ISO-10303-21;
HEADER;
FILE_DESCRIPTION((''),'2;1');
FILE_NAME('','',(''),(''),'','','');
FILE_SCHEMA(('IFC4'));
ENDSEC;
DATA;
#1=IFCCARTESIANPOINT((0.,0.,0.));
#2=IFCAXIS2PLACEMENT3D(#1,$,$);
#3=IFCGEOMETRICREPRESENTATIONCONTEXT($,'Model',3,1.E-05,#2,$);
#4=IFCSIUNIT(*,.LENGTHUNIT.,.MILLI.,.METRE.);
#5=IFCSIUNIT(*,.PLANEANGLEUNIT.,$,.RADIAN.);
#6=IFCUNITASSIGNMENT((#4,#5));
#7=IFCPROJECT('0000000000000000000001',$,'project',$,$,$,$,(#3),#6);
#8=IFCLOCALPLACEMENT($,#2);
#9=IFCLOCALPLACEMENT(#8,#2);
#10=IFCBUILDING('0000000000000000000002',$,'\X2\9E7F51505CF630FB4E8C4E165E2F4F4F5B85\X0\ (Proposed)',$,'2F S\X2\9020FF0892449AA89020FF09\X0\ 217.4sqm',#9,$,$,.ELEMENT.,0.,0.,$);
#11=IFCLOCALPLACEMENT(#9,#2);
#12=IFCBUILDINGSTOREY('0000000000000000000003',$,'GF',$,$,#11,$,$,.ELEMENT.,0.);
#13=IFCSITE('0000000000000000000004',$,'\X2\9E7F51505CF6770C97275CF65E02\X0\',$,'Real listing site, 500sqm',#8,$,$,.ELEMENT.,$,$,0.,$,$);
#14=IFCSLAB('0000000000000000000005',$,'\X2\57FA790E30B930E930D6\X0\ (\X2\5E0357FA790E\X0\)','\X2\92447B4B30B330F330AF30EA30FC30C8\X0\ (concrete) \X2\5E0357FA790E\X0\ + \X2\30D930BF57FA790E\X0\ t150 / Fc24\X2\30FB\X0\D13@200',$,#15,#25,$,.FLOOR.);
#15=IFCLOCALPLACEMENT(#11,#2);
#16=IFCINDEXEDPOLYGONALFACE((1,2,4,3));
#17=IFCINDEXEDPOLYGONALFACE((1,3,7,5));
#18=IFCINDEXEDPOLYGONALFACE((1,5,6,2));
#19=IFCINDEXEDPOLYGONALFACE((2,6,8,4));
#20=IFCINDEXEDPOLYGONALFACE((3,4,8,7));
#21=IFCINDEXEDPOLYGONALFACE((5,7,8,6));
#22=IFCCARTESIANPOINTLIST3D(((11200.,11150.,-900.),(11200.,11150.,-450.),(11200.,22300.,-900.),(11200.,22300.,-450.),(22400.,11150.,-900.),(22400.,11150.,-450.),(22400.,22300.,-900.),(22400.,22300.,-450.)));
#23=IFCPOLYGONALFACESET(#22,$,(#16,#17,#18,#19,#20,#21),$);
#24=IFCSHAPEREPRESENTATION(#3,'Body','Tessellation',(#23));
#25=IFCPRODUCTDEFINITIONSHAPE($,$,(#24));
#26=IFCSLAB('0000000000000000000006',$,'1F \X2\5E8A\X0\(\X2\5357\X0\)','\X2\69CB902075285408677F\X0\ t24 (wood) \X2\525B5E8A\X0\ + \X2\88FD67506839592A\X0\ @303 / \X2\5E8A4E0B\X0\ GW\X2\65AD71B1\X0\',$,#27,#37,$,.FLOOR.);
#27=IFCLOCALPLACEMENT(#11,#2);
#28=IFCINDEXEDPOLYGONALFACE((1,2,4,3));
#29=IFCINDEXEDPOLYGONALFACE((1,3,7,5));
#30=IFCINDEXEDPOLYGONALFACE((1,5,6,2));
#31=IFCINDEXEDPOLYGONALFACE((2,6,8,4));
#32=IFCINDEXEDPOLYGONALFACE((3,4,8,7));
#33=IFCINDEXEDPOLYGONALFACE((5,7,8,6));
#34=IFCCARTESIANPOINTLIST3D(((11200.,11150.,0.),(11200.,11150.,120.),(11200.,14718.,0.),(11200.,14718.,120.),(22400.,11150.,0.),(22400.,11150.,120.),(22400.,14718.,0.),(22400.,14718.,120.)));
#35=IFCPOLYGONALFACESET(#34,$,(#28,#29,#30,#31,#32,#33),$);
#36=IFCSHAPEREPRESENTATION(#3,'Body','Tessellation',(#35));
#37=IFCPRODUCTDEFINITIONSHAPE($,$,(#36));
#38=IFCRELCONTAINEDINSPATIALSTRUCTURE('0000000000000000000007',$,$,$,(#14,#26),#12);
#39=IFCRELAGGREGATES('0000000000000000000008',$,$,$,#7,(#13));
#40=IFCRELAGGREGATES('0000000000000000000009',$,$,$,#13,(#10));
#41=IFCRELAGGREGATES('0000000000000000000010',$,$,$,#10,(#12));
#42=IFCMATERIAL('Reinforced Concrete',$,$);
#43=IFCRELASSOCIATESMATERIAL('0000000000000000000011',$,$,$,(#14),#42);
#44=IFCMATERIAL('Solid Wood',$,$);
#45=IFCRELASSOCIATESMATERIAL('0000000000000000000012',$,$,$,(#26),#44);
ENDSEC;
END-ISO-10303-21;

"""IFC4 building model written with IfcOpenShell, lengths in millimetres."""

from ifc_helpers import new_model, si_unit, frame, frame_2d, origin, place, context, project, spatial, rectangle, extrude, material, element, save


model = new_model("IFC4")

# Units and contexts
model_context = context("Model", 3, precision=1e-05, world=origin())
ifc_project = project(units=[si_unit("LENGTHUNIT", "METRE", prefix="MILLI"), si_unit("PLANEANGLEUNIT", "RADIAN")], contexts=[model_context])

# Site, building, storey
site_placement = place(None, origin())
site = spatial("IfcSite", under=ifc_project, at=site_placement, Name="鹿児島県霧島市", ObjectType="Real listing site, 500sqm", CompositionType="ELEMENT", RefElevation=0.0)
building_placement = place(site_placement, origin())
building = spatial("IfcBuilding", under=site, at=building_placement, Name="鹿児島・二世帯住宅 (Proposed)", ObjectType="2F S造（鉄骨造） 217.4sqm", CompositionType="ELEMENT", ElevationOfRefHeight=0.0, ElevationOfTerrain=0.0)
storey_placement = place(building_placement, origin())
storey = spatial("IfcBuildingStorey", under=building, at=storey_placement, Name="GF", CompositionType="ELEMENT", Elevation=0.0)

# Shared definitions
ifc_material_1 = material(Name="Solid Wood")

# Slabs
ifc_material_2 = material(Name="Reinforced Concrete")
slab_1_placement = place(storey_placement, frame((5600.0, 5575.0, -450.0)))
element("IfcSlab", 1, at=slab_1_placement, inside=storey, material=ifc_material_2, Name="基礎スラブ (布基礎)", Description="鉄筋コンクリート (concrete) 布基礎 + ベタ基礎 t150 / Fc24・D13@200", PredefinedType="FLOOR", context=model_context, shape_type="SweptSolid", body=[
    extrude(rectangle(XDim=11200.0, YDim=11150.0, at=frame_2d((5600.0, 5575.0))), frame((5600.0, 5575.0, -450.0)), (0.0, 0.0, 1.0), 450.0),
])
slab_2_placement = place(storey_placement, frame((5600.0, 5575.0, 0.0)))
element("IfcSlab", 2, at=slab_2_placement, inside=storey, material=ifc_material_1, Name="1F 床(南)", Description="構造用合板 t24 (wood) 剛床 + 製材根太 @303 / 床下 GW断熱", PredefinedType="FLOOR", context=model_context, shape_type="SweptSolid", body=[
    extrude(rectangle(XDim=11200.0, YDim=3568.0, at=frame_2d((5600.0, 1784.0))), frame((5600.0, 5575.0, 0.0)), (0.0, 0.0, 1.0), 120.0),
])

save(model, "model.ifc")
